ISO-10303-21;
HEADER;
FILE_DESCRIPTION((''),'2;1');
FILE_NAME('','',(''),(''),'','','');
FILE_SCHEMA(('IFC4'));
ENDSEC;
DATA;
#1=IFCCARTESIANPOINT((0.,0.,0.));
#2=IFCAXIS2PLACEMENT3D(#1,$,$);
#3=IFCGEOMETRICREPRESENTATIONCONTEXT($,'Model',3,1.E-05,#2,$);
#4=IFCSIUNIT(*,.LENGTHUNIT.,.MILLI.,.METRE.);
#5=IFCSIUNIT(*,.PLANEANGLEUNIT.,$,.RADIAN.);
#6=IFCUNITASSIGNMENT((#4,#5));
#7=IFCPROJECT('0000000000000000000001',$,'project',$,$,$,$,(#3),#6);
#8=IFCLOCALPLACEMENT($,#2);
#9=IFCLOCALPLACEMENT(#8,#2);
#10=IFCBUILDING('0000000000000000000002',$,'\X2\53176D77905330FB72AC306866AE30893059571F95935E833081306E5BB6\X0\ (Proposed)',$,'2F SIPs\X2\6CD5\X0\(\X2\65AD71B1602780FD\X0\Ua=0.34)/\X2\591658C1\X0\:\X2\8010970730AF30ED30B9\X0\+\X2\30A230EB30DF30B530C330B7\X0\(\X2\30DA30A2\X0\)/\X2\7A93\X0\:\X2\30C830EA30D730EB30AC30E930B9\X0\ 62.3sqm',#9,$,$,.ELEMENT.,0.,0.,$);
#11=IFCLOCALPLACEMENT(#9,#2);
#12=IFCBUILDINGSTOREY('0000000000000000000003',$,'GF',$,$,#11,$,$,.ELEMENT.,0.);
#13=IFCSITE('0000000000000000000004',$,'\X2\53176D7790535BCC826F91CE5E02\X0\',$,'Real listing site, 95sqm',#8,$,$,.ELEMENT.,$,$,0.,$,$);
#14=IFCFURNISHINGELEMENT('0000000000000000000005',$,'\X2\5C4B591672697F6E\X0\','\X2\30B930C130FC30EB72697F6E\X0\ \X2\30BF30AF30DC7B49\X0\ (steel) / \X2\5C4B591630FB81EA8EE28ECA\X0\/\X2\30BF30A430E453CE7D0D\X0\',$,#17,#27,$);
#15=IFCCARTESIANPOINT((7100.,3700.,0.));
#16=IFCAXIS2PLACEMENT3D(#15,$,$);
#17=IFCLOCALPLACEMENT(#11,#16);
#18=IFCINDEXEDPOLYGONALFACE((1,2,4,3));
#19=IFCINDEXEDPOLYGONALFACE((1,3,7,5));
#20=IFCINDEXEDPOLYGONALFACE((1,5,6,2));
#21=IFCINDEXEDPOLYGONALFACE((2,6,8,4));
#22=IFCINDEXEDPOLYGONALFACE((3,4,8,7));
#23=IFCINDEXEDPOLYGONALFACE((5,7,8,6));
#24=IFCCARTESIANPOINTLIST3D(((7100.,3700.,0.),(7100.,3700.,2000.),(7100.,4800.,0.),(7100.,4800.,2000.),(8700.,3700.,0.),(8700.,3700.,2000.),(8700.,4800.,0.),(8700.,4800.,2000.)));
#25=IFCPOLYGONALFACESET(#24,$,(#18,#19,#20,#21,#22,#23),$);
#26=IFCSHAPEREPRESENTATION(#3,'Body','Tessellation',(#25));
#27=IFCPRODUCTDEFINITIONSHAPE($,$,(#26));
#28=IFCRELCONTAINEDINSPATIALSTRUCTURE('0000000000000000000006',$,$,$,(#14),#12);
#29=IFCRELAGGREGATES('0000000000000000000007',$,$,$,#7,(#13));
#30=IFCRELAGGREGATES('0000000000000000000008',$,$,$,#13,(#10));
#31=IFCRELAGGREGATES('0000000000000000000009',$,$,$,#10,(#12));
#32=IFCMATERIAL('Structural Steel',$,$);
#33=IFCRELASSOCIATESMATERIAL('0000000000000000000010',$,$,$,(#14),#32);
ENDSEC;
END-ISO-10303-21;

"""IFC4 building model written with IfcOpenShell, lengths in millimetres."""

from ifc_helpers import new_model, si_unit, frame, frame_2d, origin, place, context, project, spatial, rectangle, extrude, material, element, save


model = new_model("IFC4")

# Units and contexts
model_context = context("Model", 3, precision=1e-05, world=origin())
ifc_project = project(units=[si_unit("LENGTHUNIT", "METRE", prefix="MILLI"), si_unit("PLANEANGLEUNIT", "RADIAN")], contexts=[model_context])

# Site, building, storey
site_placement = place(None, origin())
site = spatial("IfcSite", under=ifc_project, at=site_placement, Name="北海道富良野市", ObjectType="Real listing site, 95sqm", CompositionType="ELEMENT", RefElevation=0.0)
building_placement = place(site_placement, origin())
building = spatial("IfcBuilding", under=site, at=building_placement, Name="北海道・犬と暮らす土間広めの家 (Proposed)", ObjectType="2F SIPs法(断熱性能Ua=0.34)/外壁:耐震クロス+アルミサッシ(ペア)/窓:トリプルガラス 62.3sqm", CompositionType="ELEMENT", ElevationOfRefHeight=0.0, ElevationOfTerrain=0.0)
storey_placement = place(building_placement, origin())
storey = spatial("IfcBuildingStorey", under=building, at=storey_placement, Name="GF", CompositionType="ELEMENT", Elevation=0.0)

# Shared definitions
ifc_material_1 = material(Name="Structural Steel")

# Furnishing element
furnishing_1_placement = place(storey_placement, frame((7100.0, 3700.0, 0.0)))
element("IfcFurnishingElement", 1, at=furnishing_1_placement, inside=storey, material=ifc_material_1, Name="屋外物置", Description="スチール物置 タクボ等 (steel) / 屋外・自転車/タイヤ収納", context=model_context, shape_type="SweptSolid", body=[
    extrude(rectangle(XDim=1600.0, YDim=1100.0, at=frame_2d((800.0, 550.0))), frame((7100.0, 3700.0, 0.0)), (0.0, 0.0, 1.0), 2000.0),
])

save(model, "model.ifc")
